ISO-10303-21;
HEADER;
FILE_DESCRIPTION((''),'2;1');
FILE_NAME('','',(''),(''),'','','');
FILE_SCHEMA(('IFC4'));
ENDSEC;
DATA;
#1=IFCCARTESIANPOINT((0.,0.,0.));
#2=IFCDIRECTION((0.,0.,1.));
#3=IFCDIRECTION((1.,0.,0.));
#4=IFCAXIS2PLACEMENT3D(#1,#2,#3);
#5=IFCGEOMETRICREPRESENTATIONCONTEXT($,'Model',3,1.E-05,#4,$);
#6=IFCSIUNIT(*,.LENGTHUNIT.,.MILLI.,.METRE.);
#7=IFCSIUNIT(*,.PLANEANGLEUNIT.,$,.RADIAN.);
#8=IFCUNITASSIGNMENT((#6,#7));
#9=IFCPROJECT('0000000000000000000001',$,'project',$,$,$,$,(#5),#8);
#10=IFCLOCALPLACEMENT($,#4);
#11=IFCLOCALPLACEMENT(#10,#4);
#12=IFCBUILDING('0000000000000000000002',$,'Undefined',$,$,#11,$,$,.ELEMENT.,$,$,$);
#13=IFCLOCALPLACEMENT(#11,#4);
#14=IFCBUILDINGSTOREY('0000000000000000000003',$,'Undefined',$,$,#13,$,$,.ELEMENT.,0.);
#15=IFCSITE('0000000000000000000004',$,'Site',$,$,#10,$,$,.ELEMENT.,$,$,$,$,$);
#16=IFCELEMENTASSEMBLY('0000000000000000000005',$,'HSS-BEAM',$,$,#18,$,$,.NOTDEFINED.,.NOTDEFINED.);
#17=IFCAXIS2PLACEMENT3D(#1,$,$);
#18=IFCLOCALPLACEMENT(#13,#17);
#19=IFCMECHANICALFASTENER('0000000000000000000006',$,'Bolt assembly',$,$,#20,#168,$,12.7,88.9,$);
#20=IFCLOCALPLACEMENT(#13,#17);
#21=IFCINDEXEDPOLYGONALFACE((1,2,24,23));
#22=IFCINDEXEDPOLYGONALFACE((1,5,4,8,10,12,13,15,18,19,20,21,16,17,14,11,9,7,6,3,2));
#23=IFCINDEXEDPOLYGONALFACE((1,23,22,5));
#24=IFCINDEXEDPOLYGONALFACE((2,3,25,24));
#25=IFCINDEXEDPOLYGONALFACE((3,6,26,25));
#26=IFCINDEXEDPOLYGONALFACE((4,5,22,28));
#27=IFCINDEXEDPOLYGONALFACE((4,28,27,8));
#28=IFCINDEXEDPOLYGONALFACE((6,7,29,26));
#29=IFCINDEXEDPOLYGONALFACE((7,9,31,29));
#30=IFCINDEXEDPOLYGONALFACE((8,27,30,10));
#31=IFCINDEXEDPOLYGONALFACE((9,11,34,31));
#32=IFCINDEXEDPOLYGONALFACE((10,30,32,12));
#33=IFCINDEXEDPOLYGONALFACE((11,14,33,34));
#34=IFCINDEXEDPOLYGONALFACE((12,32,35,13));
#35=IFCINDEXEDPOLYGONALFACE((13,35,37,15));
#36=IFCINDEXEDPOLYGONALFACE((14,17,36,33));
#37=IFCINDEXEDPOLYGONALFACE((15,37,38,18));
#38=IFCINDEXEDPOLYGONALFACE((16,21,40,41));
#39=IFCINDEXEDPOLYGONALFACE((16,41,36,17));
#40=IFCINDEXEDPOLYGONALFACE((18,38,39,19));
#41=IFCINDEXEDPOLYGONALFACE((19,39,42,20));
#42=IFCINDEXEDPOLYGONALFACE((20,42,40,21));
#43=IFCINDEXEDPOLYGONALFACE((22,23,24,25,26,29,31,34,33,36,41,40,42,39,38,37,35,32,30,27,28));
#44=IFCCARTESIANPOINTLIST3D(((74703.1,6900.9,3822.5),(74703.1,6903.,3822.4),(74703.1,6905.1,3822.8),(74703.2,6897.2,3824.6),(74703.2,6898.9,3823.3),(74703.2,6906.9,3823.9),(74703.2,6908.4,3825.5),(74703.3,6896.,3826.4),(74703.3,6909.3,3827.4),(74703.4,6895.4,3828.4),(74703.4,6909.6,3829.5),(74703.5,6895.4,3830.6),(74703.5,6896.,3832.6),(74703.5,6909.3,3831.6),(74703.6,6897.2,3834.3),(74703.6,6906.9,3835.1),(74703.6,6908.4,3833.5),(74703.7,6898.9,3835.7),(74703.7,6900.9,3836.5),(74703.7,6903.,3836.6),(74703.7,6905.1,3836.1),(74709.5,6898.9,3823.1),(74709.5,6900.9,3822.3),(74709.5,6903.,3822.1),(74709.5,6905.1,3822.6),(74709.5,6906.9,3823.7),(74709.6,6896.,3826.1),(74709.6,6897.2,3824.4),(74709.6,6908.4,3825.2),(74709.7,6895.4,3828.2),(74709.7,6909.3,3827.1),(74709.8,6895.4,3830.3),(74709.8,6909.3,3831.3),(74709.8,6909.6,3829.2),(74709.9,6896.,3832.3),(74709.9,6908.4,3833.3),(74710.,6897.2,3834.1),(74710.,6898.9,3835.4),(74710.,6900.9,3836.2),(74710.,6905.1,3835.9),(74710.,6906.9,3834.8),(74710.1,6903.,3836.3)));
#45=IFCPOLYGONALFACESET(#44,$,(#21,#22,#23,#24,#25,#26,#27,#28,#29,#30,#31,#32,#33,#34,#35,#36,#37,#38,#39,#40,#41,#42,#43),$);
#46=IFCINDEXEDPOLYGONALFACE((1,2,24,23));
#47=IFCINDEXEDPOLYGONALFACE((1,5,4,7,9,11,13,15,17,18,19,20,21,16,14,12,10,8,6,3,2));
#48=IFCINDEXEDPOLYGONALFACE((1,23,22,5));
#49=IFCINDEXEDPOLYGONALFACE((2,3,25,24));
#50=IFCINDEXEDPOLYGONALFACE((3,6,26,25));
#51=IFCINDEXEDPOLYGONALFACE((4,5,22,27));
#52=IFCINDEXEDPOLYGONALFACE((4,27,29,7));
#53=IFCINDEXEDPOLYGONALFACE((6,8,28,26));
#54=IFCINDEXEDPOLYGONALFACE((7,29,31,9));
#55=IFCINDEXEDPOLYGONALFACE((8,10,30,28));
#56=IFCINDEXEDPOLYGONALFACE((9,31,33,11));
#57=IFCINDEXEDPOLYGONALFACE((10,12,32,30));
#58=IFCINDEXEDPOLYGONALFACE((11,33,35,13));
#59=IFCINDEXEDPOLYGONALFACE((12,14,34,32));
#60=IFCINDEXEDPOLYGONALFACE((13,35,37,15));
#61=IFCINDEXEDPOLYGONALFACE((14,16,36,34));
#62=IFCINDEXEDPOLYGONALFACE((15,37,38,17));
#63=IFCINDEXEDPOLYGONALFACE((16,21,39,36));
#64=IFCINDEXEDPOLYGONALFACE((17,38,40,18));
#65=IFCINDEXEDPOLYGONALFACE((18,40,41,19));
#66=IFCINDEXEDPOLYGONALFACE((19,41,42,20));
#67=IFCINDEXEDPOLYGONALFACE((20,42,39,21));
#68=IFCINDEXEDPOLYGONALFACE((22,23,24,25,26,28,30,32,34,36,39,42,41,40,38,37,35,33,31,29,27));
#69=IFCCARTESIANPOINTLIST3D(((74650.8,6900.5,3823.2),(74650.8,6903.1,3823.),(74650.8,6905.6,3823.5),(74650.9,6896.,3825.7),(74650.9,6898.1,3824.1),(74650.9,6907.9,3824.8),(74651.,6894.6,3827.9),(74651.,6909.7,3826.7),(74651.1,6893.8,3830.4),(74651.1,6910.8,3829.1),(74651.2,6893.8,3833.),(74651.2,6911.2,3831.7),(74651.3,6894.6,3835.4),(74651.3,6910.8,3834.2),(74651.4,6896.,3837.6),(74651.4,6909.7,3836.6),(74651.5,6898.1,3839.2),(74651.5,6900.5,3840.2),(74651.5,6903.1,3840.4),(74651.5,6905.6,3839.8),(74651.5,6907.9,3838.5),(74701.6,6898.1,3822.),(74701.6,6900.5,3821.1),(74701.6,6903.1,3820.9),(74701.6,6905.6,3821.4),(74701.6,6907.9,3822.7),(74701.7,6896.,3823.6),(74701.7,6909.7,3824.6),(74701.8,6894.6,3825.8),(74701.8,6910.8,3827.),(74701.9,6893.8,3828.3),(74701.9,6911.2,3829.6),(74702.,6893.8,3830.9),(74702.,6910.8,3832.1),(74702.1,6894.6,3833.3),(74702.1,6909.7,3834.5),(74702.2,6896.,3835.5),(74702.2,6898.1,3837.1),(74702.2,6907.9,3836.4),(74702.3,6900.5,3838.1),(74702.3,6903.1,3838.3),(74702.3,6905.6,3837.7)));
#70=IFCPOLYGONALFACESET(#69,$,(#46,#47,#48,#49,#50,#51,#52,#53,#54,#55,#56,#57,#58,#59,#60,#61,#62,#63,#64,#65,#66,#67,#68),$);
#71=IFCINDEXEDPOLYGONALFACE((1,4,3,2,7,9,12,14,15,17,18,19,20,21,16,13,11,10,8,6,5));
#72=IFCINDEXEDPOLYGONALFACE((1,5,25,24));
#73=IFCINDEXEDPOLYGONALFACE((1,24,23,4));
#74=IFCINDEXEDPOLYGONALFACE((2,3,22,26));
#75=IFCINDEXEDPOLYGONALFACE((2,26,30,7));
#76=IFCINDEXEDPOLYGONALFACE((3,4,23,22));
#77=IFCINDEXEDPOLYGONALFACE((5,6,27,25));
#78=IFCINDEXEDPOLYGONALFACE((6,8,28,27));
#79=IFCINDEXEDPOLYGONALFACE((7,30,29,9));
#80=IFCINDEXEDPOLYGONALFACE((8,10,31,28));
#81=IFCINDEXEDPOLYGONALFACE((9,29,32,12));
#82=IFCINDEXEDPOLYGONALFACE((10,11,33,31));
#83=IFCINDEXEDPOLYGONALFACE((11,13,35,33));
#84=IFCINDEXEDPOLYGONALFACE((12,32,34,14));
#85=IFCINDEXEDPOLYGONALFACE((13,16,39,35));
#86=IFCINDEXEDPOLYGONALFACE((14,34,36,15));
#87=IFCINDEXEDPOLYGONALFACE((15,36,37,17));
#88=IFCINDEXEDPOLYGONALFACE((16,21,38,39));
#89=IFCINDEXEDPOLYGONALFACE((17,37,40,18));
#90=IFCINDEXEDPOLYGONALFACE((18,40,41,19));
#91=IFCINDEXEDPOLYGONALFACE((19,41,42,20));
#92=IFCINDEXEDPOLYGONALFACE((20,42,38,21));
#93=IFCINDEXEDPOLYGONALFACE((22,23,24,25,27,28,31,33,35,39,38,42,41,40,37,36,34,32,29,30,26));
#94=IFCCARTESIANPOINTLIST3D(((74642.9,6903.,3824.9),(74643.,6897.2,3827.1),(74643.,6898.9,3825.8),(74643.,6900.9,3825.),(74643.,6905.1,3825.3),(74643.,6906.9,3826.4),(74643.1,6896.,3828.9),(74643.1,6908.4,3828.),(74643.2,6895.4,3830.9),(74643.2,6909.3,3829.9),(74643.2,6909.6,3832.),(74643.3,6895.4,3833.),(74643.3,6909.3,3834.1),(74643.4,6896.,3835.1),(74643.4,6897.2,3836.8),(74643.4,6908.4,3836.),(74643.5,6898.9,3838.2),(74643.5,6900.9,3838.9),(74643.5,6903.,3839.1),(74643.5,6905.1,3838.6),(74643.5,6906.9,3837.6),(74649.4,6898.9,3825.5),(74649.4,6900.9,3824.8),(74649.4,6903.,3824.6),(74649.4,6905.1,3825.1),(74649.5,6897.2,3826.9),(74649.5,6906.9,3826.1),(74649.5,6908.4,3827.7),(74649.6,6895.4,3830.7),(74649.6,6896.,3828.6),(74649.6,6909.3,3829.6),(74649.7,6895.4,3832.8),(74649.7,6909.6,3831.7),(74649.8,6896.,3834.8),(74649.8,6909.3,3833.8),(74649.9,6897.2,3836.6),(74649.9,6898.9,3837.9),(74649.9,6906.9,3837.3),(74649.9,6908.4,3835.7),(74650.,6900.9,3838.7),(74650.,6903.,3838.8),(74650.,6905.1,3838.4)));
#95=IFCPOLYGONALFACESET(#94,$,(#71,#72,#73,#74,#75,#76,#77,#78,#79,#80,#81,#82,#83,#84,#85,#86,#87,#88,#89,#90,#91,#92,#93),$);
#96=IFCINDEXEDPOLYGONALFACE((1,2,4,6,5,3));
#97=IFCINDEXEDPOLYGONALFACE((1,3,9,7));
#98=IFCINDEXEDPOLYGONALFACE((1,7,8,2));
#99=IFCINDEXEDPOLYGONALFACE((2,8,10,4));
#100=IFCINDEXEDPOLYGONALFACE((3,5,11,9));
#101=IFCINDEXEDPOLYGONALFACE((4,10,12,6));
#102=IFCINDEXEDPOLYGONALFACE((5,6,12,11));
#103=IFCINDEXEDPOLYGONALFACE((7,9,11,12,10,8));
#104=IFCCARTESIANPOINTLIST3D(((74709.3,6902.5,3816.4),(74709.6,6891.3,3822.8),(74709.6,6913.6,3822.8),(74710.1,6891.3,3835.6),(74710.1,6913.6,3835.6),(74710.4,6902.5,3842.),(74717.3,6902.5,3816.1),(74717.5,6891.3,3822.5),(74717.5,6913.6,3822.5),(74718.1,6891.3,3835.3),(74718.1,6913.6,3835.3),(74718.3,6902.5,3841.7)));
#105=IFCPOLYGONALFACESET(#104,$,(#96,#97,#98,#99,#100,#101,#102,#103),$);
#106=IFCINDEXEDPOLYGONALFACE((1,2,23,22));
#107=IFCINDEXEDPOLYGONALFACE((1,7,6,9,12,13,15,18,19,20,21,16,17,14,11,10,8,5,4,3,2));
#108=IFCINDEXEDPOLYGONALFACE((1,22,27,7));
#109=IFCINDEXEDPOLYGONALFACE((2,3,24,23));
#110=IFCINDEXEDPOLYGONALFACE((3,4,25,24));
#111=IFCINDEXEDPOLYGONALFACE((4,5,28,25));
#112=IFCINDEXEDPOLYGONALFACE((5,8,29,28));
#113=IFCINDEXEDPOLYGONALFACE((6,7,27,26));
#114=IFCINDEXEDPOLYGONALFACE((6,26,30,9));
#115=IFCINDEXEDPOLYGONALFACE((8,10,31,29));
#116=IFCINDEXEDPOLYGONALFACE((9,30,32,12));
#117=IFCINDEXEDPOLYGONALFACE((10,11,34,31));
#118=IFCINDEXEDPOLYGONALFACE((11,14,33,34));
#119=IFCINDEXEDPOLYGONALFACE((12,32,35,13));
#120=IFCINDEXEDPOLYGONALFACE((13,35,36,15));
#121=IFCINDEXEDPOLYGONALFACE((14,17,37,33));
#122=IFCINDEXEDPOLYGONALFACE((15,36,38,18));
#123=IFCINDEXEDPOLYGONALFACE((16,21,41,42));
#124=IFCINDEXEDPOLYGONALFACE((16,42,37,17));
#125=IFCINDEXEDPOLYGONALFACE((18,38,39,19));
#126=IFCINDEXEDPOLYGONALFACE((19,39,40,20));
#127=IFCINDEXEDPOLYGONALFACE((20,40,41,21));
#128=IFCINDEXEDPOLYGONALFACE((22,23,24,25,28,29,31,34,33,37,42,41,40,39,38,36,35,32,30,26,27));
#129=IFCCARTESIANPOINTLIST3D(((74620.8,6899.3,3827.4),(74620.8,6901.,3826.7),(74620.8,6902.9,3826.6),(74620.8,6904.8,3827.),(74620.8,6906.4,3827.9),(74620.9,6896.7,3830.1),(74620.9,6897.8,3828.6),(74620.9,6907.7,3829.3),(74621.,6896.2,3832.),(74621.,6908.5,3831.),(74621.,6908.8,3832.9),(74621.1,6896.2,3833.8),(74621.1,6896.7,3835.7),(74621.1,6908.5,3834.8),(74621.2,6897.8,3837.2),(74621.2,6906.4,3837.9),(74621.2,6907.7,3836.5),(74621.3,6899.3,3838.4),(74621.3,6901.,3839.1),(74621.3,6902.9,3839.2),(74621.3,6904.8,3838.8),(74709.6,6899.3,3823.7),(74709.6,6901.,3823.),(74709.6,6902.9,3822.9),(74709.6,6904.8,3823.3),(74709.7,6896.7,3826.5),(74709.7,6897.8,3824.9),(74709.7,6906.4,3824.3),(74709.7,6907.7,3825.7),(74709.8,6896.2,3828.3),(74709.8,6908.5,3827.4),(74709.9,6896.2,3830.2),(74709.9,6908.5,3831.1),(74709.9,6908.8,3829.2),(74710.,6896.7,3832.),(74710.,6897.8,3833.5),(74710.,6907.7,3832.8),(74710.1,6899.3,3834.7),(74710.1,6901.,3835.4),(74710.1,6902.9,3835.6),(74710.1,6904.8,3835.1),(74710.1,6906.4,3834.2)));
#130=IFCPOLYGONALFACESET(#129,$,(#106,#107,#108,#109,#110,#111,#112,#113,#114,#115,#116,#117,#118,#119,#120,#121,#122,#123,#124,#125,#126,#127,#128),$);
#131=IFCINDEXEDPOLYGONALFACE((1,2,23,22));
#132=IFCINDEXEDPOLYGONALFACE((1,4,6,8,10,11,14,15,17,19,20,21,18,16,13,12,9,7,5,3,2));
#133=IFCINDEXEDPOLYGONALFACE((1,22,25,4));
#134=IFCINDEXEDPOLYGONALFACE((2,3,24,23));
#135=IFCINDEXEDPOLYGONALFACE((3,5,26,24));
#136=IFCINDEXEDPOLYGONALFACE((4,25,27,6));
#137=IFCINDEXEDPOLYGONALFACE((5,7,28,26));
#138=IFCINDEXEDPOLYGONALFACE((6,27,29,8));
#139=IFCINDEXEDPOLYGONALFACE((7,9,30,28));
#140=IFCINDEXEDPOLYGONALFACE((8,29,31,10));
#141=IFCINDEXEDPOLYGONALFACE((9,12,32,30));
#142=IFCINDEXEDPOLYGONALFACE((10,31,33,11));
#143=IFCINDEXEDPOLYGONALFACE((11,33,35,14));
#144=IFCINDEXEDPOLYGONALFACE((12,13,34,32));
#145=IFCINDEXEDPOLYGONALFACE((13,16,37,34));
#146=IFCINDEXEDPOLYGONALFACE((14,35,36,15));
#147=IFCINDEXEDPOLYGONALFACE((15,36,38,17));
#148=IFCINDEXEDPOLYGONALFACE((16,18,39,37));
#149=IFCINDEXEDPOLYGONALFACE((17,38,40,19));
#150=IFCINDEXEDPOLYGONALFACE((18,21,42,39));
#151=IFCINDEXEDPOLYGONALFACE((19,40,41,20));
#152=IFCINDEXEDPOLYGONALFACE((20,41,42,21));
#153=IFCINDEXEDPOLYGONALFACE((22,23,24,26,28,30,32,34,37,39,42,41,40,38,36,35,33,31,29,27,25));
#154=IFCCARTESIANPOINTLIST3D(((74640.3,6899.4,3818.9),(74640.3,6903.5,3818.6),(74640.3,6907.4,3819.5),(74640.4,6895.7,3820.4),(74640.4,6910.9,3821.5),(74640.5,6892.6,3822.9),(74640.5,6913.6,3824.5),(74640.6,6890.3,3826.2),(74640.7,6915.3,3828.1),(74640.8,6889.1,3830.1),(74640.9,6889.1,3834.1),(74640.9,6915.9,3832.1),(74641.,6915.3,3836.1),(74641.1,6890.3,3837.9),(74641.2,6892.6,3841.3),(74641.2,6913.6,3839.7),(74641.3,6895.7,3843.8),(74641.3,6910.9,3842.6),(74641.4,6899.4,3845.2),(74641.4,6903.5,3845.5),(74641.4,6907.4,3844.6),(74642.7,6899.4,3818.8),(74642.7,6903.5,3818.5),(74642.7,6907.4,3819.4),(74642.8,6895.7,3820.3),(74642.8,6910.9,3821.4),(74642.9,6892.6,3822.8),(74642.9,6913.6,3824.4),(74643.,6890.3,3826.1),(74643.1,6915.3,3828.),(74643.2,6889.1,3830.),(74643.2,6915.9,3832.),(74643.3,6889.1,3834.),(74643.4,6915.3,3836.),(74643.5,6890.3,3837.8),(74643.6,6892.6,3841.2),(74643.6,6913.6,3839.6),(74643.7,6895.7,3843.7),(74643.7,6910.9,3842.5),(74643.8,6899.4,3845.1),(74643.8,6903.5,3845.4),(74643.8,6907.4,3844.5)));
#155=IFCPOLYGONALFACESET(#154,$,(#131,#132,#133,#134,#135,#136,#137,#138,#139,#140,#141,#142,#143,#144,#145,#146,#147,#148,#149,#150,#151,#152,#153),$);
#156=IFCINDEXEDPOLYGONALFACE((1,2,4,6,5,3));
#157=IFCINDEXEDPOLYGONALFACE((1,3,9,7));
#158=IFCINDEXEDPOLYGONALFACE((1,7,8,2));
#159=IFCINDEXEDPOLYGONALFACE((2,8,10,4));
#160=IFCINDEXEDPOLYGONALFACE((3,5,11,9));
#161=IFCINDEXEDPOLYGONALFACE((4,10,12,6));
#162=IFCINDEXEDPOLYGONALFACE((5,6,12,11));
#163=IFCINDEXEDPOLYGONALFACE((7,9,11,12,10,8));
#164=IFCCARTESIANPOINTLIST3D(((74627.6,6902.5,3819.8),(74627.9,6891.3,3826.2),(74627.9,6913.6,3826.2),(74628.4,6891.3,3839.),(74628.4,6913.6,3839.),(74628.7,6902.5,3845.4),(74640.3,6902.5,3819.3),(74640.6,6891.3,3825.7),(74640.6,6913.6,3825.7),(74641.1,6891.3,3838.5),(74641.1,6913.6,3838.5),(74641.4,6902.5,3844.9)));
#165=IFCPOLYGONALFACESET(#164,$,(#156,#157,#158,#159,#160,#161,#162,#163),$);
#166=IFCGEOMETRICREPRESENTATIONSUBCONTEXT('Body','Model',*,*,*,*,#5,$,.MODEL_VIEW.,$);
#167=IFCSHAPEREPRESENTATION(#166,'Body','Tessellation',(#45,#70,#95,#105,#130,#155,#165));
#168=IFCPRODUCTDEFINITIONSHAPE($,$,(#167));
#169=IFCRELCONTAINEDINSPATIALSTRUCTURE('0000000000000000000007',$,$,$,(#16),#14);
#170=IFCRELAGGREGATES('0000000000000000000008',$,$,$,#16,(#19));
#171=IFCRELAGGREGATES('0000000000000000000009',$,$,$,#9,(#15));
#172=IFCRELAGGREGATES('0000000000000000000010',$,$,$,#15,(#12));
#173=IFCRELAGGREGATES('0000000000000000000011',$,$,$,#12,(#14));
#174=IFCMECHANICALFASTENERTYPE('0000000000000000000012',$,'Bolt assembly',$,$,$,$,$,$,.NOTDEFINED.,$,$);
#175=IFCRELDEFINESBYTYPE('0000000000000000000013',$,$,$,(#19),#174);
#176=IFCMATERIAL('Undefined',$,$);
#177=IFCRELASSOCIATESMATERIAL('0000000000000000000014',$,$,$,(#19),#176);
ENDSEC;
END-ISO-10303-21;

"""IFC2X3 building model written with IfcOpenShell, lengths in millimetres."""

from ifc_helpers import new_model, si_unit, frame, origin_with_axes, origin_2d_with_axis, place, context, subcontext, project, spatial, polyline, circle, outline, extrude, source, transform, mapped, material, type_object, element, aggregate, save


model = new_model("IFC2X3")

# Units and contexts
model_context = context("Model", 3, precision=1e-05, world=origin_with_axes())
body_context = subcontext(model_context, "Body", "Model", "MODEL_VIEW")
ifc_project = project(units=[si_unit("LENGTHUNIT", "METRE", prefix="MILLI"), si_unit("PLANEANGLEUNIT", "RADIAN")], contexts=[model_context])

# Site, building, storey
site_placement = place(None, origin_with_axes())
site = spatial("IfcSite", under=ifc_project, at=site_placement, Name="Site", CompositionType="ELEMENT")
building_placement = place(site_placement, origin_with_axes())
building = spatial("IfcBuilding", under=site, at=building_placement, Name="Undefined", CompositionType="ELEMENT")
storey_placement = place(building_placement, origin_with_axes())
storey = spatial("IfcBuildingStorey", under=building, at=storey_placement, Name="Undefined", CompositionType="ELEMENT", Elevation=0.0)

# Shared definitions
ifc_material_1 = material(Name="Undefined")
mechanical_fastener_type = type_object("IfcMechanicalFastenerType", Name="Bolt assembly")

# Element assembly, mechanical fastener
assembly_1_placement = place(storey_placement, origin_with_axes())
assembly_1 = element("IfcElementAssembly", 1, at=assembly_1_placement, inside=storey, Name="HSS-BEAM", AssemblyPlace="NOTDEFINED", PredefinedType="NOTDEFINED")
shared_shape_1 = source(origin_with_axes(), body_context, "Body", "SweptSolid", [
    extrude(circle(Radius=7.1, at=origin_2d_with_axis()), frame((0.0, -33.2, 0.0), z_axis=(0.0, 1.0, 0.0), x_axis=(1.0, 0.0, 0.0)), (0.0, 0.0, 1.0), 6.3),
    extrude(circle(Radius=8.7, at=origin_2d_with_axis()), frame((0.0, -25.4, 0.0), z_axis=(0.0, 1.0, 0.0), x_axis=(1.0, 0.0, 0.0)), (0.0, 0.0, 1.0), 50.8),
    extrude(circle(Radius=7.1, at=origin_2d_with_axis()), frame((0.0, 26.9, 0.0), z_axis=(0.0, 1.0, 0.0), x_axis=(1.0, 0.0, 0.0)), (0.0, 0.0, 1.0), 6.5),
    extrude(outline(polyline([(11.1, -6.4), (11.1, 6.4), (0.0, 12.8), (-11.1, 6.4), (-11.1, -6.4), (0.0, -12.8), (11.1, -6.4)])), frame((0.0, -41.3, 0.0), z_axis=(0.0, 1.0, 0.0), x_axis=(1.0, 0.0, 0.0)), (0.0, 0.0, 1.0), 7.9),
    extrude(circle(Radius=6.3, at=origin_2d_with_axis()), frame((0.0, -33.3, 0.0), z_axis=(0.0, 1.0, 0.0), x_axis=(1.0, 0.0, 0.0)), (0.0, 0.0, 1.0), 88.9),
    extrude(circle(Radius=13.5, at=origin_2d_with_axis()), frame((0.0, 33.3, 0.0), z_axis=(0.0, 1.0, 0.0), x_axis=(1.0, 0.0, 0.0)), (0.0, 0.0, 1.0), 2.4),
    extrude(outline(polyline([(11.1, -6.4), (11.1, 6.4), (0.0, 12.8), (-11.1, 6.4), (-11.1, -6.4), (0.0, -12.8), (11.1, -6.4)])), frame((0.0, 35.7, 0.0), z_axis=(0.0, 1.0, 0.0), x_axis=(1.0, 0.0, 0.0)), (0.0, 0.0, 1.0), 12.7),
])
mechanical_fastener_1_placement = place(assembly_1_placement, frame((74676.6, 6902.5, 3830.6), z_axis=(0.041337, 0.0, 0.999145), x_axis=(0.0, 1.0, 0.0)))
mechanical_fastener_1 = element("IfcMechanicalFastener", 2, at=mechanical_fastener_1_placement, type_object=mechanical_fastener_type, material=ifc_material_1, Name="Bolt assembly", NominalDiameter=12.7, NominalLength=88.9, context=body_context, shape_type="MappedRepresentation", body=[
    mapped(shared_shape_1, transform((0.0, 0.0, 0.0))),
])
aggregate(assembly_1, [mechanical_fastener_1])

save(model, "model.ifc")
